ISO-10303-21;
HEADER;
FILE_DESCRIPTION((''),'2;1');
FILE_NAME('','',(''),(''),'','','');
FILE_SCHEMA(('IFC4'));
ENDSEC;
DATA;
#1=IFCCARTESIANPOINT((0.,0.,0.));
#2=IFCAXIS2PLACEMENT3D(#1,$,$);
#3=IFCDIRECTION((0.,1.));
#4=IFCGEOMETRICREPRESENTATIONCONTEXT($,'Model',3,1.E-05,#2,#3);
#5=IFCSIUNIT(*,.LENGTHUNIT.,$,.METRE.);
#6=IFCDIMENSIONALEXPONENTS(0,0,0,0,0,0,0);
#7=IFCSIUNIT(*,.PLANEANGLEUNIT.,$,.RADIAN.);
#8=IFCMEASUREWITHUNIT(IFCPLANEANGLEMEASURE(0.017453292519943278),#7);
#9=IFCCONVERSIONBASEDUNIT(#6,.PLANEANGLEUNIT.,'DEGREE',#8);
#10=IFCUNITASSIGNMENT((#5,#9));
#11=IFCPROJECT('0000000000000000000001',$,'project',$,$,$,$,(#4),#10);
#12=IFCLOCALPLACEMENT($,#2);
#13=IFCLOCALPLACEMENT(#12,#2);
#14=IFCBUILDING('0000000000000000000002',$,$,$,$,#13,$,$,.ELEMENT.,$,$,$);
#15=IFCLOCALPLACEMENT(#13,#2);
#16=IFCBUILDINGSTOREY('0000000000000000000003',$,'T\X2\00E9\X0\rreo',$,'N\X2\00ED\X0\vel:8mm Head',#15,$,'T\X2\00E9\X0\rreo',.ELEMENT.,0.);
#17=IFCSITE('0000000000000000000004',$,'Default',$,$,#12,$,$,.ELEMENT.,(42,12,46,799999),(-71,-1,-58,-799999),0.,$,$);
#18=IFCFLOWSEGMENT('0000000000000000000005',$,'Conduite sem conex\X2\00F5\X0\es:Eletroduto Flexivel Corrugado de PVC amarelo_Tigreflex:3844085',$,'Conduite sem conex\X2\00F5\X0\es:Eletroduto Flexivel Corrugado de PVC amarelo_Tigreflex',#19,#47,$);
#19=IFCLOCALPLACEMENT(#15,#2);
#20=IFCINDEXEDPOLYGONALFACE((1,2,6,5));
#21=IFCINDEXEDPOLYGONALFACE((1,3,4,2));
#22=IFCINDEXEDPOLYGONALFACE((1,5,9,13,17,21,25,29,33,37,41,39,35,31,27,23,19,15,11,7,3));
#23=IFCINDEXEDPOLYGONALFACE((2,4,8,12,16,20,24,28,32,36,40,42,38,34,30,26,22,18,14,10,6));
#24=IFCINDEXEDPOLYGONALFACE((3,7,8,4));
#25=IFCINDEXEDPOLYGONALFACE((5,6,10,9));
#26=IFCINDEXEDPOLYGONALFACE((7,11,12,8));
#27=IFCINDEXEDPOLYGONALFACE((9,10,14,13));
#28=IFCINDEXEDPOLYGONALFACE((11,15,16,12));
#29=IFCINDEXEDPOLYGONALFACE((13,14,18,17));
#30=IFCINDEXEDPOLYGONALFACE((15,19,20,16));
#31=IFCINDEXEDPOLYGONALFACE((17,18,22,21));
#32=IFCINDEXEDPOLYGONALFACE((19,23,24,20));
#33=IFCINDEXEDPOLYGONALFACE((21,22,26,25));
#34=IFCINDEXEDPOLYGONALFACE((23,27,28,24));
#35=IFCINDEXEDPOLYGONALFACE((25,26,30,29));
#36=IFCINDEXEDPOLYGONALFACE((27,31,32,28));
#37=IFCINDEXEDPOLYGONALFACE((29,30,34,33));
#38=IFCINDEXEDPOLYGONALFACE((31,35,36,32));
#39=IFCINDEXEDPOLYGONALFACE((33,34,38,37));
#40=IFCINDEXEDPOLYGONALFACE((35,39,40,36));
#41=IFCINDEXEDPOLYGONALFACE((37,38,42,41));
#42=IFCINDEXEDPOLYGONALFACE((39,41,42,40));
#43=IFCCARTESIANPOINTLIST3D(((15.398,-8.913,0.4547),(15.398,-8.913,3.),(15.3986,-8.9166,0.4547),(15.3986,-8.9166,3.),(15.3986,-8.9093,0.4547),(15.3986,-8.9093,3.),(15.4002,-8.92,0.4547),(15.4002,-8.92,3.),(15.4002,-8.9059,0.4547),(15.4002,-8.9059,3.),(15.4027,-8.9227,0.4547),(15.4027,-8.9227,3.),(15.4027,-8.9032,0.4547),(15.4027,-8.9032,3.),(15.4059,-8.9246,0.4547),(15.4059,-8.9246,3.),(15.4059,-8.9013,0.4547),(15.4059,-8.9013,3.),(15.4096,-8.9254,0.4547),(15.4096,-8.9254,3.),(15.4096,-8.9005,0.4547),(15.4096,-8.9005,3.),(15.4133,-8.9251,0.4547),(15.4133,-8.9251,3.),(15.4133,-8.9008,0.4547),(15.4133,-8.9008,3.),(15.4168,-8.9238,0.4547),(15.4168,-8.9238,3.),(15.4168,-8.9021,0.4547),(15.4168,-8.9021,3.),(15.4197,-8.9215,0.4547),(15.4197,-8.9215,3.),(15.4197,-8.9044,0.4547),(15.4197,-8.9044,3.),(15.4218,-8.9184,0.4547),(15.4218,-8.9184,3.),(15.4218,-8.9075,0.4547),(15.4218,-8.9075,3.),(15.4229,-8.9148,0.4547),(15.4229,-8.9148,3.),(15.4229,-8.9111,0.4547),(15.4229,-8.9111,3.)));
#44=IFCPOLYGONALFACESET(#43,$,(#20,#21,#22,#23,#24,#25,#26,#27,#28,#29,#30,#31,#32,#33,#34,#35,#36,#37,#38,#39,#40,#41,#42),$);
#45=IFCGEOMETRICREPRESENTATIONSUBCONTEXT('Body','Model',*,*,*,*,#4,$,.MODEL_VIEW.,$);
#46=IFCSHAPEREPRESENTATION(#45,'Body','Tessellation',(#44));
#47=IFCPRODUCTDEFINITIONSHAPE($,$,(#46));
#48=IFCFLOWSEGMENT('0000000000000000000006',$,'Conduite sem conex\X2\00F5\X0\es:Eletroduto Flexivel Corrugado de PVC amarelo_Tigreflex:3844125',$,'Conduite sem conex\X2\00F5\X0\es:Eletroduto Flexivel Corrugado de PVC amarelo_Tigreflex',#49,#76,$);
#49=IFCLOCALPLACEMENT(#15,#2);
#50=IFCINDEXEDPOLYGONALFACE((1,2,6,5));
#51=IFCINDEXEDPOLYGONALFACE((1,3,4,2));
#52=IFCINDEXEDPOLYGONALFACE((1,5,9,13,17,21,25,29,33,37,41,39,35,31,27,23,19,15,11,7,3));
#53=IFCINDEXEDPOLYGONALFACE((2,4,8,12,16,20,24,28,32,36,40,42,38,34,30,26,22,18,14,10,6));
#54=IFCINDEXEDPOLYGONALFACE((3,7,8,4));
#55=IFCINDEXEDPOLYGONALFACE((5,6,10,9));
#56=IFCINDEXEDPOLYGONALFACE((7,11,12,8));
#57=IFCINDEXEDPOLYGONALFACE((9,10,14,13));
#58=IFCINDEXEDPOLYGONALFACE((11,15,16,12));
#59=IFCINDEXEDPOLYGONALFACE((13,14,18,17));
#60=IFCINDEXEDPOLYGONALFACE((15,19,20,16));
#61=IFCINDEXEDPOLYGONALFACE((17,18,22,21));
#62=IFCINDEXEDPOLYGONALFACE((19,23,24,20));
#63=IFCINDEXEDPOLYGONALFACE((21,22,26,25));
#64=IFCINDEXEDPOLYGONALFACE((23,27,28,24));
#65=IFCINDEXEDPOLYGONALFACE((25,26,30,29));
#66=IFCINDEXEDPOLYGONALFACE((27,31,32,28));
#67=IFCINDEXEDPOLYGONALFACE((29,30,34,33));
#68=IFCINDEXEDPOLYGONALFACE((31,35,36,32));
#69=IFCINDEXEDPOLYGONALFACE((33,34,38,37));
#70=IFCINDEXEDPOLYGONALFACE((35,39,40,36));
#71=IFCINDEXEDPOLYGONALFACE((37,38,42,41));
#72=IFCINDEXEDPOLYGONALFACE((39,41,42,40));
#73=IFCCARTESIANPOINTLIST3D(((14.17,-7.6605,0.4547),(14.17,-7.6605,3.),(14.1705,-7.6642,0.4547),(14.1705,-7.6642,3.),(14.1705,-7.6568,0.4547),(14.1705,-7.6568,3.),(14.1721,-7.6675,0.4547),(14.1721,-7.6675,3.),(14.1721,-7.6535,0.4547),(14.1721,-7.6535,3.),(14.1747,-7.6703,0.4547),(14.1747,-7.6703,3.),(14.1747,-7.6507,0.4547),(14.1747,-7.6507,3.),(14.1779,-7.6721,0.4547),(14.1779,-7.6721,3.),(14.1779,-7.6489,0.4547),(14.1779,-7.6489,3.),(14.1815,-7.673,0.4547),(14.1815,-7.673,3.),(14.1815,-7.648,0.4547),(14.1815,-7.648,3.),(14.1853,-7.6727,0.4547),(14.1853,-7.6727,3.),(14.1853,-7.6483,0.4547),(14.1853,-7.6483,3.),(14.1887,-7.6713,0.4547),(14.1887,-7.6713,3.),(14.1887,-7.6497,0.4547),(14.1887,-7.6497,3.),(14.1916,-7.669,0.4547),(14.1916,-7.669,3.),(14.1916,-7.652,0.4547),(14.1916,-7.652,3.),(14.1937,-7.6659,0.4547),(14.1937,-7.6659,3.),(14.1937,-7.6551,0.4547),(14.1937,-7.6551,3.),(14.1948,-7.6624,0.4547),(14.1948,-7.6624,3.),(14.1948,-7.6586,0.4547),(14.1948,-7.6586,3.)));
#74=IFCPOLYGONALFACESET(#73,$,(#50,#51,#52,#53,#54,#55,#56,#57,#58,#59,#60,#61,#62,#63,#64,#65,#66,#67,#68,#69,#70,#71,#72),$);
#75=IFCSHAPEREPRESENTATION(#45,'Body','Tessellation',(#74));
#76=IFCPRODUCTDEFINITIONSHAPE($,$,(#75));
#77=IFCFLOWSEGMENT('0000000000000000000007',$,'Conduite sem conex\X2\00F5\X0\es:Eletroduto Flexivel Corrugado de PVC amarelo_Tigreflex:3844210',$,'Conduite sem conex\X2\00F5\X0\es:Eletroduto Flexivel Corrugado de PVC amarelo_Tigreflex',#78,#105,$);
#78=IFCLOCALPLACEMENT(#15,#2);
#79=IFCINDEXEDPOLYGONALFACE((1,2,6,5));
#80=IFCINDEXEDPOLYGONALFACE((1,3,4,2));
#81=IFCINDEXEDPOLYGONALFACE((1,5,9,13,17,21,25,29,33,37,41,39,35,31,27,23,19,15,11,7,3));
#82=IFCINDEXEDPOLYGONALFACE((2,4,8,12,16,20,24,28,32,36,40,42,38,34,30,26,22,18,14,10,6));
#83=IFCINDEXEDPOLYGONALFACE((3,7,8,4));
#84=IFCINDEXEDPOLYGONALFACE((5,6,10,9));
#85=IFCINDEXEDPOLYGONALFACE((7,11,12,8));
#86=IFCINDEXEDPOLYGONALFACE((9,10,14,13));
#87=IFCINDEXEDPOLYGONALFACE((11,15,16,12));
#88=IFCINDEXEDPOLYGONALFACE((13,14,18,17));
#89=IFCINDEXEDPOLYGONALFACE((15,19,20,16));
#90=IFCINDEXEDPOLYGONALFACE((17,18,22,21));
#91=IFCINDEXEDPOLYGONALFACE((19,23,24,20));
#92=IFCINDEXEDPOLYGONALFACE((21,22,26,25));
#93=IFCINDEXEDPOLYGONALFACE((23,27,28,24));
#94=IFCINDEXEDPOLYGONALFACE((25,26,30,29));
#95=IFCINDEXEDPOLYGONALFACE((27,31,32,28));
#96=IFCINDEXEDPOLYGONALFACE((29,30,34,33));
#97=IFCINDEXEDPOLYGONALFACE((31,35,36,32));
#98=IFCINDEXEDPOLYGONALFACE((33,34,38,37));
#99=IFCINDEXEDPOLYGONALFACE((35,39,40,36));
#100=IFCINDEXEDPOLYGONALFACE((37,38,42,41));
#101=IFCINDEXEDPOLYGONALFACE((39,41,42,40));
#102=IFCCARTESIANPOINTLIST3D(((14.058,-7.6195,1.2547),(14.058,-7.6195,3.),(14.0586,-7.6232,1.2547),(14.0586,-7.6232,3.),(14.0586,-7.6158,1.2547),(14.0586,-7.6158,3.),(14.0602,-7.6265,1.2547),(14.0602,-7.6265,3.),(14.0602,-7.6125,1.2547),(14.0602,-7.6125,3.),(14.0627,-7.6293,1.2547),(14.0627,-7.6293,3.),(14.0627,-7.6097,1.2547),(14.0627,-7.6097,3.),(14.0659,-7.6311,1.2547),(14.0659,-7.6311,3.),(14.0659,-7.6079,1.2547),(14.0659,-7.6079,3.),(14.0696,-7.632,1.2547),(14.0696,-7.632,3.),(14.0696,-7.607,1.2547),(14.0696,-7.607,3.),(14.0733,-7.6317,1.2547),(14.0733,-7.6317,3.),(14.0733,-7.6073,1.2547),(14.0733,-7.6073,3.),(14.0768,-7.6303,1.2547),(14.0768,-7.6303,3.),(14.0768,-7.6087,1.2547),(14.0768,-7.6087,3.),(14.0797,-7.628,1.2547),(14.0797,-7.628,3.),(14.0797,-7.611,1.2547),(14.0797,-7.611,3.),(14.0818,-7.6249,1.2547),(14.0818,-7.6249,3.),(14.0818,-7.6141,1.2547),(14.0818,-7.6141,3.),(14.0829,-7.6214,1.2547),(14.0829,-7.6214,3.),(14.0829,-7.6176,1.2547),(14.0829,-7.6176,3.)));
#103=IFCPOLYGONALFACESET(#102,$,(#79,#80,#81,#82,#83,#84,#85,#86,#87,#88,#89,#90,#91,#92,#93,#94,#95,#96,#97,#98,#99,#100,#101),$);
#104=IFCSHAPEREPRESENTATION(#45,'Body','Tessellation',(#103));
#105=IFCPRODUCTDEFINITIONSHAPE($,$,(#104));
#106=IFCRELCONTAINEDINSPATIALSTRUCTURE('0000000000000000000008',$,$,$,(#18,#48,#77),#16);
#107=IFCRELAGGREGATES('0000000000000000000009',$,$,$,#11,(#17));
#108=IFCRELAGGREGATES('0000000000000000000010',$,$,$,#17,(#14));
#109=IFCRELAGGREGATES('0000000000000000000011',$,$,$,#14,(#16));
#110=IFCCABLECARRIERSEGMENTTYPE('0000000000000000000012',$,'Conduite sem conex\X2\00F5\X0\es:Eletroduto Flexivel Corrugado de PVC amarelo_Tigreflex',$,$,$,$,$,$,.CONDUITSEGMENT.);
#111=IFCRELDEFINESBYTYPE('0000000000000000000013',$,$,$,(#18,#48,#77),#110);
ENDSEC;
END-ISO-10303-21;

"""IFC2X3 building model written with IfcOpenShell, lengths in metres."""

from ifc_helpers import new_model, entity, si_unit, converted_unit, direction, frame, frame_2d, origin, place, context, subcontext, project, spatial, circle, extrude, type_object, element, save


model = new_model("IFC2X3")

# Units and contexts
model_context = context("Model", 3, precision=1e-05, world=origin(), true_north=direction((0.0, 1.0)))
body_context = subcontext(model_context, "Body", "Model", "MODEL_VIEW")
ifc_project = project(units=[si_unit("LENGTHUNIT", "METRE"), converted_unit("PLANEANGLEUNIT", "DEGREE", entity("IfcPlaneAngleMeasure", 0.017453292519943278), si_unit("PLANEANGLEUNIT", "RADIAN"), dimensions=[0, 0, 0, 0, 0, 0, 0])], contexts=[model_context])

# Site, building, storey
site_placement = place(None, origin())
site = spatial("IfcSite", under=ifc_project, at=site_placement, Name="Default", CompositionType="ELEMENT", RefLatitude=(42, 12, 46, 799999), RefLongitude=(-71, -1, -58, -799999), RefElevation=0.0)
building_placement = place(site_placement, origin())
building = spatial("IfcBuilding", under=site, at=building_placement, CompositionType="ELEMENT")
storey_placement = place(building_placement, origin())
storey = spatial("IfcBuildingStorey", under=building, at=storey_placement, Name="Térreo", ObjectType="Nível:8mm Head", LongName="Térreo", CompositionType="ELEMENT", Elevation=0.0)

# Flow segments
cable_carrier_segment_type = type_object("IfcCableCarrierSegmentType", Name="Conduite sem conexões:Eletroduto Flexivel Corrugado de PVC amarelo_Tigreflex", PredefinedType="CONDUITSEGMENT")
flow_segment_1_placement = place(storey_placement, origin())
element("IfcFlowSegment", 1, at=flow_segment_1_placement, inside=storey, type_object=cable_carrier_segment_type, Name="Conduite sem conexões:Eletroduto Flexivel Corrugado de PVC amarelo_Tigreflex:3844085", ObjectType="Conduite sem conexões:Eletroduto Flexivel Corrugado de PVC amarelo_Tigreflex", context=body_context, shape_type="SweptSolid", body=[
    extrude(circle(Radius=0.0125, at=frame_2d((0.0, 0.0), x_axis=(1.0, 0.0))), frame((15.4105, -8.913, 0.4547), z_axis=(0.0, 0.0, 1.0), x_axis=(-1.0, 0.0, 0.0)), (0.0, 0.0, 1.0), 2.5453),
])
flow_segment_2_placement = place(storey_placement, origin())
element("IfcFlowSegment", 2, at=flow_segment_2_placement, inside=storey, type_object=cable_carrier_segment_type, Name="Conduite sem conexões:Eletroduto Flexivel Corrugado de PVC amarelo_Tigreflex:3844125", ObjectType="Conduite sem conexões:Eletroduto Flexivel Corrugado de PVC amarelo_Tigreflex", context=body_context, shape_type="SweptSolid", body=[
    extrude(circle(Radius=0.0125, at=frame_2d((0.0, 0.0), x_axis=(1.0, 0.0))), frame((14.1825, -7.6605, 0.4547), z_axis=(0.0, 0.0, 1.0), x_axis=(-1.0, 0.0, 0.0)), (0.0, 0.0, 1.0), 2.5453),
])
flow_segment_3_placement = place(storey_placement, origin())
element("IfcFlowSegment", 3, at=flow_segment_3_placement, inside=storey, type_object=cable_carrier_segment_type, Name="Conduite sem conexões:Eletroduto Flexivel Corrugado de PVC amarelo_Tigreflex:3844210", ObjectType="Conduite sem conexões:Eletroduto Flexivel Corrugado de PVC amarelo_Tigreflex", context=body_context, shape_type="SweptSolid", body=[
    extrude(circle(Radius=0.0125, at=frame_2d((0.0, 0.0), x_axis=(1.0, 0.0))), frame((14.0705, -7.6195, 1.2547), z_axis=(0.0, 0.0, 1.0), x_axis=(-1.0, 0.0, 0.0)), (0.0, 0.0, 1.0), 1.7453),
])

save(model, "model.ifc")
